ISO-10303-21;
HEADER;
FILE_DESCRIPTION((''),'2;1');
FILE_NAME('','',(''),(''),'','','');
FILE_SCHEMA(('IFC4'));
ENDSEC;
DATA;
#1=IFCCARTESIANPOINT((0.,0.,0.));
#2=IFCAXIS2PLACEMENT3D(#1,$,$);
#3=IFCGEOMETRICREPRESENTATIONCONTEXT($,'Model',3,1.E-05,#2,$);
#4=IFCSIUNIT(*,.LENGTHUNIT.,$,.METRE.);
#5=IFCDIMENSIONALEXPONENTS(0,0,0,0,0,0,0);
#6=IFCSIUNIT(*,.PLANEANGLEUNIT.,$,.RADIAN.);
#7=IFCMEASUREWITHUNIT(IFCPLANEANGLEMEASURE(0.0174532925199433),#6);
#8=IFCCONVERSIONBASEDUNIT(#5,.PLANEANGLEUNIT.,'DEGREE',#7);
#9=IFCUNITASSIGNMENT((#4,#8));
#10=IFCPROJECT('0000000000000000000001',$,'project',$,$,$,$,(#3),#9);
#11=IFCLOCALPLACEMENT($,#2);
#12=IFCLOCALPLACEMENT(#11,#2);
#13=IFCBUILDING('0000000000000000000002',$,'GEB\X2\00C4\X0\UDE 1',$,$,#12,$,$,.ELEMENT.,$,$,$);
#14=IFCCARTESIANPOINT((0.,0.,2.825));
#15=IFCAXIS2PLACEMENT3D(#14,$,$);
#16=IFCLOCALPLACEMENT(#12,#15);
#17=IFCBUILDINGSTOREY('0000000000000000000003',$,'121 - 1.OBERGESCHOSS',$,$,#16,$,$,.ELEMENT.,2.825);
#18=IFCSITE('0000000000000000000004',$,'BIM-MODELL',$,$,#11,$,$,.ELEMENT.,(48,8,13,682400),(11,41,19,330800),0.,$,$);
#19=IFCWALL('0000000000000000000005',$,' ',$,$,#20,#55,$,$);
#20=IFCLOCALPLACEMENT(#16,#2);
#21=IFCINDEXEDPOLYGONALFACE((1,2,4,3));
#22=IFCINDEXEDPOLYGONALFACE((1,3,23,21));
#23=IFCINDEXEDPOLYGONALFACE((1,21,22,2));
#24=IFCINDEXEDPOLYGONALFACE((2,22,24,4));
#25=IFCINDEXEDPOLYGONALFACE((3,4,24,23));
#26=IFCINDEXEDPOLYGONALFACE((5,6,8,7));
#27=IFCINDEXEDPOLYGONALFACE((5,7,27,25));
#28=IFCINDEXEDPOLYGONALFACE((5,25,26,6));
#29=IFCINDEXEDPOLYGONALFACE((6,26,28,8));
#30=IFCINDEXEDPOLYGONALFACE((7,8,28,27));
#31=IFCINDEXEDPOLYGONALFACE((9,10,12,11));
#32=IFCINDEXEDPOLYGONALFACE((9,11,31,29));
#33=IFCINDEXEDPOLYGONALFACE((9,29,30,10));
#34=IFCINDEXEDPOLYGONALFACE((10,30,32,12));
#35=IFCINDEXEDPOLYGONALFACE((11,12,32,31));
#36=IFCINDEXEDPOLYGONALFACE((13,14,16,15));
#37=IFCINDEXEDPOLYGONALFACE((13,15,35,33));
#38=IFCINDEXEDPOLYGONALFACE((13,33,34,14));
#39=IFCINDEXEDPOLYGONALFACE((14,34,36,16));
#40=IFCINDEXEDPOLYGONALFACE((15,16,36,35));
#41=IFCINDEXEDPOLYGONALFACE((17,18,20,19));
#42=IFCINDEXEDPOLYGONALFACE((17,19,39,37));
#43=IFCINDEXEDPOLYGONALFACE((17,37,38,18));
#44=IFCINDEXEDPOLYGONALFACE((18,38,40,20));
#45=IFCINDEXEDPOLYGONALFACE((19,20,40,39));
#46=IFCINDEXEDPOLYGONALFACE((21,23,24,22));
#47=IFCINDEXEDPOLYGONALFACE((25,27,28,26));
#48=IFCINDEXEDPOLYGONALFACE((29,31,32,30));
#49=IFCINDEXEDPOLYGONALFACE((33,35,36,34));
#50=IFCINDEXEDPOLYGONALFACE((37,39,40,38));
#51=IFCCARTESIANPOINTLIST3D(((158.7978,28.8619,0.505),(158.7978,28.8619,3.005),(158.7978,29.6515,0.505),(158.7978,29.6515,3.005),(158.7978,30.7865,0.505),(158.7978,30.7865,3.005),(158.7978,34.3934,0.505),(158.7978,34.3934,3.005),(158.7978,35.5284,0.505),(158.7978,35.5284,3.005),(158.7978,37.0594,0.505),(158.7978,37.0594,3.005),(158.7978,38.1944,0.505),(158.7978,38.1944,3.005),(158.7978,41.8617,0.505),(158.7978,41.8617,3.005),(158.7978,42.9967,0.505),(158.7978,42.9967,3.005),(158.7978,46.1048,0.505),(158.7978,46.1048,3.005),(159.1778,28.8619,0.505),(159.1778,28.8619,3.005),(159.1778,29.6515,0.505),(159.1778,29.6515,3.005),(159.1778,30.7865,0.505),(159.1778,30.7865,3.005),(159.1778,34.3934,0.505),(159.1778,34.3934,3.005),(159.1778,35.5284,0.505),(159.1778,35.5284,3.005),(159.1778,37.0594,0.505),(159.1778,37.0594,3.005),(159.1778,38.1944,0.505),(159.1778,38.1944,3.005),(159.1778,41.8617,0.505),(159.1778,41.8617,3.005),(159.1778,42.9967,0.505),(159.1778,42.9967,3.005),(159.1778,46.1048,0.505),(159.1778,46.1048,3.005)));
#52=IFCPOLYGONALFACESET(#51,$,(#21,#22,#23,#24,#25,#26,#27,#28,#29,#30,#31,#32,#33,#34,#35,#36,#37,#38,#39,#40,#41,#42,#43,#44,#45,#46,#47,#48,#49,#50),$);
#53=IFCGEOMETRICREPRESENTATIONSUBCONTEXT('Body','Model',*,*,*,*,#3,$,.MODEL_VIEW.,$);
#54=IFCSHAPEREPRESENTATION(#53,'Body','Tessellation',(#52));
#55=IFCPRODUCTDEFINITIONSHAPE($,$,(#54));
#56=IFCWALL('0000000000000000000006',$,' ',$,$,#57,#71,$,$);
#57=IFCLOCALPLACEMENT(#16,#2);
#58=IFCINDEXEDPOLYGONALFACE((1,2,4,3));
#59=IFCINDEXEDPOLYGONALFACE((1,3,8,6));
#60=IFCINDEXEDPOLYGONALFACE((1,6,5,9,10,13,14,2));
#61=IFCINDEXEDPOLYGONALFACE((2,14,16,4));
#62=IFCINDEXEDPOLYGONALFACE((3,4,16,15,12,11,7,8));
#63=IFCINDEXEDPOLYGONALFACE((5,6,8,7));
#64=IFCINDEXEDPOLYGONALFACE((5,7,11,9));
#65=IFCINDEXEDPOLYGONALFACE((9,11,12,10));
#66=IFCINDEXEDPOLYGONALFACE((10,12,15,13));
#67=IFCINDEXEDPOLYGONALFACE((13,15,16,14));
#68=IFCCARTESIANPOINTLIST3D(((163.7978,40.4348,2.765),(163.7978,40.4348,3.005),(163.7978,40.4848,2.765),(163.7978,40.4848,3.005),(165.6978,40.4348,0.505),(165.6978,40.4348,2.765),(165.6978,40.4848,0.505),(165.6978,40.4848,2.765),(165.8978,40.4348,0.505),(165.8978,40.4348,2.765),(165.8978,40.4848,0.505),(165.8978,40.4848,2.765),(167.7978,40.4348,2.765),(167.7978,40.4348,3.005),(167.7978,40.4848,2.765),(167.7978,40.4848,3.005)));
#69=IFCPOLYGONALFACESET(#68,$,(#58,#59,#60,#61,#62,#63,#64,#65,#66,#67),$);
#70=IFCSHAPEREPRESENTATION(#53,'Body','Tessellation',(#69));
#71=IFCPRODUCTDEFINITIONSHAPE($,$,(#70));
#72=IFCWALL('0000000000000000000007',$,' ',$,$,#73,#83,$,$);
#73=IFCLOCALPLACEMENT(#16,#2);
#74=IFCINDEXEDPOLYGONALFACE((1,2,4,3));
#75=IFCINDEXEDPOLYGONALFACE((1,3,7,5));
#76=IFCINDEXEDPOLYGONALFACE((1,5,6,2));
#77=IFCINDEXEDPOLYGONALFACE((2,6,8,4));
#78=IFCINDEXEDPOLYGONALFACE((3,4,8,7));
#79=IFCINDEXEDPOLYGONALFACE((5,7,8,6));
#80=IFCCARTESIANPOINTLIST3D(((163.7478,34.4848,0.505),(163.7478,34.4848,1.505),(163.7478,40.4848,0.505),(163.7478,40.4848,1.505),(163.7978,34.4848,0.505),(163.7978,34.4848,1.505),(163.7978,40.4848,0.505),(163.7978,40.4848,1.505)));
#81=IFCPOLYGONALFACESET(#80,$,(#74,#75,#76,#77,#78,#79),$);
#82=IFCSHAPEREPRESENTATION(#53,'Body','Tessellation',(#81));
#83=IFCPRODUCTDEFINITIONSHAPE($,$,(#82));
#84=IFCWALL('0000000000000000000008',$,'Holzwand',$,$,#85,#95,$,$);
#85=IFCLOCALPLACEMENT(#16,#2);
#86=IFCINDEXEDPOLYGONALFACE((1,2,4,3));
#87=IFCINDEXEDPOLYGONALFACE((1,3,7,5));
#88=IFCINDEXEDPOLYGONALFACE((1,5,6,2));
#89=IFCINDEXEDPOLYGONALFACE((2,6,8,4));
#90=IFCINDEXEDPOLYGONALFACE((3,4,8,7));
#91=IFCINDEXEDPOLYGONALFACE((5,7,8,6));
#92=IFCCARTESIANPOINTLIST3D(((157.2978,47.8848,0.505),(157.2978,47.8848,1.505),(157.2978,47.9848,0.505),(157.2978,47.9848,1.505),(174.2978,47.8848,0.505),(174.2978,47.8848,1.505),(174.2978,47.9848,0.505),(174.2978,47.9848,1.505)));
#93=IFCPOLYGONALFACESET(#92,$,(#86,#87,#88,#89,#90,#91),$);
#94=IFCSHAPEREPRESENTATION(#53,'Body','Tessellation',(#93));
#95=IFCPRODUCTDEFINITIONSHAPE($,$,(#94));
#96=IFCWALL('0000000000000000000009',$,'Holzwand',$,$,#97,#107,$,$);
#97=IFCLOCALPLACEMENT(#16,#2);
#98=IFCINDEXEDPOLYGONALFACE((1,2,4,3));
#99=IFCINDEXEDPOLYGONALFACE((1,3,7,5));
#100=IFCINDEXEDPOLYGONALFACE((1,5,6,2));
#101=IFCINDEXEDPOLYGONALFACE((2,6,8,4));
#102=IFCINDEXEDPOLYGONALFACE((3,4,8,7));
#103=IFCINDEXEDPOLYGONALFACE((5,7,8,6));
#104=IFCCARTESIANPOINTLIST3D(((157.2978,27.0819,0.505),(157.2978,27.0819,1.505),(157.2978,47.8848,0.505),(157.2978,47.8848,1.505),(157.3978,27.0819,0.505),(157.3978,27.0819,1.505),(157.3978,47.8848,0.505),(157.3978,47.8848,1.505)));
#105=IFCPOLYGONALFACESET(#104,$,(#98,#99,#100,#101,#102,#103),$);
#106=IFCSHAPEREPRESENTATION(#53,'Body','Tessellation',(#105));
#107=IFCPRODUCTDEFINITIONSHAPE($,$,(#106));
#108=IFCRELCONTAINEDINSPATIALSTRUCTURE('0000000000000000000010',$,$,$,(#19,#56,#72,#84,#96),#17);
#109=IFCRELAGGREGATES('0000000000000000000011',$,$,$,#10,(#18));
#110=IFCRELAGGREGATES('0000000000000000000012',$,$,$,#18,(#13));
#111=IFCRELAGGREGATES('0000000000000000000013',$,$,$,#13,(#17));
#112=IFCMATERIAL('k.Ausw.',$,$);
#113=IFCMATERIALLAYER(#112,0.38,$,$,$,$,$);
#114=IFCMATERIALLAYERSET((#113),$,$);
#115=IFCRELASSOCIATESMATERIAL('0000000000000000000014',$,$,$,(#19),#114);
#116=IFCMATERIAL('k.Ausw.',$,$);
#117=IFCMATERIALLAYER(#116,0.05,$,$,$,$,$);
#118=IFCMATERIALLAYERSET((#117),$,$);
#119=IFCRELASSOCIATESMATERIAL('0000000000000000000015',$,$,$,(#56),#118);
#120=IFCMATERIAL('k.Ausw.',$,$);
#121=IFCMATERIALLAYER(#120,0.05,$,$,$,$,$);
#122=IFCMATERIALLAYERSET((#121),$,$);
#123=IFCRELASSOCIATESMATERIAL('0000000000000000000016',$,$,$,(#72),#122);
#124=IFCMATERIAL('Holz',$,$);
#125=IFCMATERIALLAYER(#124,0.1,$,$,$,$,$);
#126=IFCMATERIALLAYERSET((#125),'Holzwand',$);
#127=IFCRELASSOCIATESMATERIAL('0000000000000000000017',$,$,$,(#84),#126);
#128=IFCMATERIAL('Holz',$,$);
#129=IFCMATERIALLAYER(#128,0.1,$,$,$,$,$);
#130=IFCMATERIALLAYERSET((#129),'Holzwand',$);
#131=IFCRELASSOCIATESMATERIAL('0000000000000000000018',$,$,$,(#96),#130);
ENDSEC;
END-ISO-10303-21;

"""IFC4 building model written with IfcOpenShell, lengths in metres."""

from ifc_helpers import new_model, entity, si_unit, converted_unit, frame, frame_2d, origin, origin_with_axes, place, context, subcontext, project, spatial, polyline, rectangle, outline, extrude, material, layer, layer_set, layer_usage, element, save


model = new_model("IFC4")

# Units and contexts
model_context = context("Model", 3, precision=1e-05, world=origin())
body_context = subcontext(model_context, "Body", "Model", "MODEL_VIEW")
ifc_project = project(units=[si_unit("LENGTHUNIT", "METRE"), converted_unit("PLANEANGLEUNIT", "DEGREE", entity("IfcPlaneAngleMeasure", 0.0174532925199433), si_unit("PLANEANGLEUNIT", "RADIAN"), dimensions=[0, 0, 0, 0, 0, 0, 0])], contexts=[model_context])

# Site, building, storey
site_placement = place(None, origin())
site = spatial("IfcSite", under=ifc_project, at=site_placement, Name="BIM-MODELL", CompositionType="ELEMENT", RefLatitude=(48, 8, 13, 682400), RefLongitude=(11, 41, 19, 330800), RefElevation=0.0)
building_placement = place(site_placement, origin())
building = spatial("IfcBuilding", under=site, at=building_placement, Name="GEBÄUDE 1", CompositionType="ELEMENT")
storey_placement = place(building_placement, frame((0.0, 0.0, 2.825)))
storey = spatial("IfcBuildingStorey", under=building, at=storey_placement, Name="121 - 1.OBERGESCHOSS", CompositionType="ELEMENT", Elevation=2.825)

# Walls, openings
ifc_material_1 = material(Name="k.Ausw.")
ifc_layer_1 = layer(ifc_material_1, 0.38)
ifc_layer_set_1 = layer_set([ifc_layer_1])
ifc_layer_usage_1 = layer_usage(ifc_layer_set_1, "AXIS2", "POSITIVE", 0.0)
wall_1_placement = place(storey_placement, frame((158.7978, 46.1048, 0.505), z_axis=(0.0, 0.0, 1.0), x_axis=(0.0, -1.0, 0.0)))
wall_1 = element("IfcWall", 1, at=wall_1_placement, inside=storey, material=ifc_layer_usage_1, Name=" ", context=body_context, shape_type="SweptSolid", body=[
    extrude(rectangle(XDim=17.2429, YDim=0.38, at=frame_2d((8.6214, 0.19), x_axis=(1.0, 0.0))), origin_with_axes(), (0.0, 0.0, 1.0), 2.5),
])
opening_1_placement = place(wall_1_placement, frame((4.2431, 0.38, 0.0), z_axis=(0.0, -1.0, 0.0), x_axis=(0.0, 0.0, 1.0)))
element("IfcOpeningElement", 2, at=opening_1_placement, cuts=wall_1, ObjectType="Opening", context=body_context, shape_type="SweptSolid", body=[
    extrude(outline(polyline([(0.0, 1.135), (2.5, 1.135), (2.5, 0.0), (0.0, 0.0), (0.0, 1.135)])), origin_with_axes(), (0.0, 0.0, 1.0), 0.38),
])
opening_2_placement = place(wall_1_placement, frame((9.0454, 0.38, 0.0), z_axis=(0.0, -1.0, 0.0), x_axis=(0.0, 0.0, 1.0)))
element("IfcOpeningElement", 3, at=opening_2_placement, cuts=wall_1, ObjectType="Opening", context=body_context, shape_type="SweptSolid", body=[
    extrude(outline(polyline([(0.0, 1.135), (2.5, 1.135), (2.5, 0.0), (0.0, 0.0), (0.0, 1.135)])), origin_with_axes(), (0.0, 0.0, 1.0), 0.38),
])
opening_3_placement = place(wall_1_placement, frame((11.7114, 0.38, 0.0), z_axis=(0.0, -1.0, 0.0), x_axis=(0.0, 0.0, 1.0)))
element("IfcOpeningElement", 4, at=opening_3_placement, cuts=wall_1, ObjectType="Opening", context=body_context, shape_type="SweptSolid", body=[
    extrude(outline(polyline([(0.0, 1.135), (2.5, 1.135), (2.5, 0.0), (0.0, 0.0), (0.0, 1.135)])), origin_with_axes(), (0.0, 0.0, 1.0), 0.38),
])
opening_4_placement = place(wall_1_placement, frame((16.4533, 0.38, 0.0), z_axis=(0.0, -1.0, 0.0), x_axis=(0.0, 0.0, 1.0)))
element("IfcOpeningElement", 5, at=opening_4_placement, cuts=wall_1, ObjectType="Opening", context=body_context, shape_type="SweptSolid", body=[
    extrude(outline(polyline([(0.0, 1.135), (2.5, 1.135), (2.5, 0.0), (0.0, 0.0), (0.0, 1.135)])), origin_with_axes(), (0.0, 0.0, 1.0), 0.38),
])
ifc_material_2 = material(Name="k.Ausw.")
ifc_layer_2 = layer(ifc_material_2, 0.05)
ifc_layer_set_2 = layer_set([ifc_layer_2])
ifc_layer_usage_2 = layer_usage(ifc_layer_set_2, "AXIS2", "POSITIVE", 0.0)
wall_2_placement = place(storey_placement, frame((167.7978, 40.4848, 0.505), z_axis=(0.0, 0.0, 1.0), x_axis=(-1.0, 0.0, 0.0)))
wall_2 = element("IfcWall", 6, at=wall_2_placement, inside=storey, material=ifc_layer_usage_2, Name=" ", context=body_context, shape_type="SweptSolid", body=[
    extrude(rectangle(XDim=4.0, YDim=0.05, at=frame_2d((2.0, 0.025), x_axis=(1.0, 0.0))), origin_with_axes(), (0.0, 0.0, 1.0), 2.5),
])
opening_5_placement = place(wall_2_placement, frame((0.0, 0.0, 0.0), z_axis=(0.0, 1.0, 0.0), x_axis=(0.0, 0.0, 1.0)))
element("IfcOpeningElement", 7, at=opening_5_placement, cuts=wall_2, ObjectType="Opening", context=body_context, shape_type="SweptSolid", body=[
    extrude(outline(polyline([(0.0, 1.9), (2.26, 1.9), (2.26, 0.0), (0.0, 0.0), (0.0, 1.9)])), origin_with_axes(), (0.0, 0.0, 1.0), 0.05),
])
opening_6_placement = place(wall_2_placement, frame((0.0, 0.0, 0.0), z_axis=(0.0, 1.0, 0.0), x_axis=(0.0, 0.0, 1.0)))
element("IfcOpeningElement", 8, at=opening_6_placement, cuts=wall_2, ObjectType="Opening", context=body_context, shape_type="SweptSolid", body=[
    extrude(outline(polyline([(0.0, 1.9), (2.26, 1.9), (2.26, 0.0), (0.0, 0.0), (0.0, 1.9)])), origin_with_axes(), (0.0, 0.0, 1.0), 0.05),
])
opening_7_placement = place(wall_2_placement, frame((2.1, 0.0, 0.0), z_axis=(0.0, 1.0, 0.0), x_axis=(0.0, 0.0, 1.0)))
element("IfcOpeningElement", 9, at=opening_7_placement, cuts=wall_2, ObjectType="Opening", context=body_context, shape_type="SweptSolid", body=[
    extrude(outline(polyline([(0.0, 1.9), (2.26, 1.9), (2.26, 0.0), (0.0, 0.0), (0.0, 1.9)])), origin_with_axes(), (0.0, 0.0, 1.0), 0.05),
])

# Walls
ifc_material_3 = material(Name="k.Ausw.")
ifc_layer_3 = layer(ifc_material_3, 0.05)
ifc_layer_set_3 = layer_set([ifc_layer_3])
ifc_layer_usage_3 = layer_usage(ifc_layer_set_3, "AXIS2", "POSITIVE", 0.0)
wall_3_placement = place(storey_placement, frame((163.7478, 40.4848, 0.505), z_axis=(0.0, 0.0, 1.0), x_axis=(0.0, -1.0, 0.0)))
element("IfcWall", 10, at=wall_3_placement, inside=storey, material=ifc_layer_usage_3, Name=" ", context=body_context, shape_type="SweptSolid", body=[
    extrude(rectangle(XDim=6.0, YDim=0.05, at=frame_2d((3.0, 0.025), x_axis=(1.0, 0.0))), origin_with_axes(), (0.0, 0.0, 1.0), 1.0),
])
ifc_material_4 = material(Name="Holz")
ifc_layer_4 = layer(ifc_material_4, 0.1)
ifc_layer_set_4 = layer_set([ifc_layer_4], Name="Holzwand")
ifc_layer_usage_4 = layer_usage(ifc_layer_set_4, "AXIS2", "POSITIVE", 0.0)
wall_4_placement = place(storey_placement, frame((174.2978, 47.9848, 0.505), z_axis=(0.0, 0.0, 1.0), x_axis=(-1.0, 0.0, 0.0)))
element("IfcWall", 11, at=wall_4_placement, inside=storey, material=ifc_layer_usage_4, Name="Holzwand", context=body_context, shape_type="SweptSolid", body=[
    extrude(rectangle(XDim=17.0, YDim=0.1, at=frame_2d((8.5, 0.05), x_axis=(1.0, 0.0))), origin_with_axes(), (0.0, 0.0, 1.0), 1.0),
])
ifc_material_5 = material(Name="Holz")
ifc_layer_5 = layer(ifc_material_5, 0.1)
ifc_layer_set_5 = layer_set([ifc_layer_5], Name="Holzwand")
ifc_layer_usage_5 = layer_usage(ifc_layer_set_5, "AXIS2", "POSITIVE", 0.0)
wall_5_placement = place(storey_placement, frame((157.2978, 47.8848, 0.505), z_axis=(0.0, 0.0, 1.0), x_axis=(0.0, -1.0, 0.0)))
element("IfcWall", 12, at=wall_5_placement, inside=storey, material=ifc_layer_usage_5, Name="Holzwand", context=body_context, shape_type="SweptSolid", body=[
    extrude(rectangle(XDim=20.8029, YDim=0.1, at=frame_2d((10.4014, 0.05), x_axis=(1.0, 0.0))), origin_with_axes(), (0.0, 0.0, 1.0), 1.0),
])

save(model, "model.ifc")
